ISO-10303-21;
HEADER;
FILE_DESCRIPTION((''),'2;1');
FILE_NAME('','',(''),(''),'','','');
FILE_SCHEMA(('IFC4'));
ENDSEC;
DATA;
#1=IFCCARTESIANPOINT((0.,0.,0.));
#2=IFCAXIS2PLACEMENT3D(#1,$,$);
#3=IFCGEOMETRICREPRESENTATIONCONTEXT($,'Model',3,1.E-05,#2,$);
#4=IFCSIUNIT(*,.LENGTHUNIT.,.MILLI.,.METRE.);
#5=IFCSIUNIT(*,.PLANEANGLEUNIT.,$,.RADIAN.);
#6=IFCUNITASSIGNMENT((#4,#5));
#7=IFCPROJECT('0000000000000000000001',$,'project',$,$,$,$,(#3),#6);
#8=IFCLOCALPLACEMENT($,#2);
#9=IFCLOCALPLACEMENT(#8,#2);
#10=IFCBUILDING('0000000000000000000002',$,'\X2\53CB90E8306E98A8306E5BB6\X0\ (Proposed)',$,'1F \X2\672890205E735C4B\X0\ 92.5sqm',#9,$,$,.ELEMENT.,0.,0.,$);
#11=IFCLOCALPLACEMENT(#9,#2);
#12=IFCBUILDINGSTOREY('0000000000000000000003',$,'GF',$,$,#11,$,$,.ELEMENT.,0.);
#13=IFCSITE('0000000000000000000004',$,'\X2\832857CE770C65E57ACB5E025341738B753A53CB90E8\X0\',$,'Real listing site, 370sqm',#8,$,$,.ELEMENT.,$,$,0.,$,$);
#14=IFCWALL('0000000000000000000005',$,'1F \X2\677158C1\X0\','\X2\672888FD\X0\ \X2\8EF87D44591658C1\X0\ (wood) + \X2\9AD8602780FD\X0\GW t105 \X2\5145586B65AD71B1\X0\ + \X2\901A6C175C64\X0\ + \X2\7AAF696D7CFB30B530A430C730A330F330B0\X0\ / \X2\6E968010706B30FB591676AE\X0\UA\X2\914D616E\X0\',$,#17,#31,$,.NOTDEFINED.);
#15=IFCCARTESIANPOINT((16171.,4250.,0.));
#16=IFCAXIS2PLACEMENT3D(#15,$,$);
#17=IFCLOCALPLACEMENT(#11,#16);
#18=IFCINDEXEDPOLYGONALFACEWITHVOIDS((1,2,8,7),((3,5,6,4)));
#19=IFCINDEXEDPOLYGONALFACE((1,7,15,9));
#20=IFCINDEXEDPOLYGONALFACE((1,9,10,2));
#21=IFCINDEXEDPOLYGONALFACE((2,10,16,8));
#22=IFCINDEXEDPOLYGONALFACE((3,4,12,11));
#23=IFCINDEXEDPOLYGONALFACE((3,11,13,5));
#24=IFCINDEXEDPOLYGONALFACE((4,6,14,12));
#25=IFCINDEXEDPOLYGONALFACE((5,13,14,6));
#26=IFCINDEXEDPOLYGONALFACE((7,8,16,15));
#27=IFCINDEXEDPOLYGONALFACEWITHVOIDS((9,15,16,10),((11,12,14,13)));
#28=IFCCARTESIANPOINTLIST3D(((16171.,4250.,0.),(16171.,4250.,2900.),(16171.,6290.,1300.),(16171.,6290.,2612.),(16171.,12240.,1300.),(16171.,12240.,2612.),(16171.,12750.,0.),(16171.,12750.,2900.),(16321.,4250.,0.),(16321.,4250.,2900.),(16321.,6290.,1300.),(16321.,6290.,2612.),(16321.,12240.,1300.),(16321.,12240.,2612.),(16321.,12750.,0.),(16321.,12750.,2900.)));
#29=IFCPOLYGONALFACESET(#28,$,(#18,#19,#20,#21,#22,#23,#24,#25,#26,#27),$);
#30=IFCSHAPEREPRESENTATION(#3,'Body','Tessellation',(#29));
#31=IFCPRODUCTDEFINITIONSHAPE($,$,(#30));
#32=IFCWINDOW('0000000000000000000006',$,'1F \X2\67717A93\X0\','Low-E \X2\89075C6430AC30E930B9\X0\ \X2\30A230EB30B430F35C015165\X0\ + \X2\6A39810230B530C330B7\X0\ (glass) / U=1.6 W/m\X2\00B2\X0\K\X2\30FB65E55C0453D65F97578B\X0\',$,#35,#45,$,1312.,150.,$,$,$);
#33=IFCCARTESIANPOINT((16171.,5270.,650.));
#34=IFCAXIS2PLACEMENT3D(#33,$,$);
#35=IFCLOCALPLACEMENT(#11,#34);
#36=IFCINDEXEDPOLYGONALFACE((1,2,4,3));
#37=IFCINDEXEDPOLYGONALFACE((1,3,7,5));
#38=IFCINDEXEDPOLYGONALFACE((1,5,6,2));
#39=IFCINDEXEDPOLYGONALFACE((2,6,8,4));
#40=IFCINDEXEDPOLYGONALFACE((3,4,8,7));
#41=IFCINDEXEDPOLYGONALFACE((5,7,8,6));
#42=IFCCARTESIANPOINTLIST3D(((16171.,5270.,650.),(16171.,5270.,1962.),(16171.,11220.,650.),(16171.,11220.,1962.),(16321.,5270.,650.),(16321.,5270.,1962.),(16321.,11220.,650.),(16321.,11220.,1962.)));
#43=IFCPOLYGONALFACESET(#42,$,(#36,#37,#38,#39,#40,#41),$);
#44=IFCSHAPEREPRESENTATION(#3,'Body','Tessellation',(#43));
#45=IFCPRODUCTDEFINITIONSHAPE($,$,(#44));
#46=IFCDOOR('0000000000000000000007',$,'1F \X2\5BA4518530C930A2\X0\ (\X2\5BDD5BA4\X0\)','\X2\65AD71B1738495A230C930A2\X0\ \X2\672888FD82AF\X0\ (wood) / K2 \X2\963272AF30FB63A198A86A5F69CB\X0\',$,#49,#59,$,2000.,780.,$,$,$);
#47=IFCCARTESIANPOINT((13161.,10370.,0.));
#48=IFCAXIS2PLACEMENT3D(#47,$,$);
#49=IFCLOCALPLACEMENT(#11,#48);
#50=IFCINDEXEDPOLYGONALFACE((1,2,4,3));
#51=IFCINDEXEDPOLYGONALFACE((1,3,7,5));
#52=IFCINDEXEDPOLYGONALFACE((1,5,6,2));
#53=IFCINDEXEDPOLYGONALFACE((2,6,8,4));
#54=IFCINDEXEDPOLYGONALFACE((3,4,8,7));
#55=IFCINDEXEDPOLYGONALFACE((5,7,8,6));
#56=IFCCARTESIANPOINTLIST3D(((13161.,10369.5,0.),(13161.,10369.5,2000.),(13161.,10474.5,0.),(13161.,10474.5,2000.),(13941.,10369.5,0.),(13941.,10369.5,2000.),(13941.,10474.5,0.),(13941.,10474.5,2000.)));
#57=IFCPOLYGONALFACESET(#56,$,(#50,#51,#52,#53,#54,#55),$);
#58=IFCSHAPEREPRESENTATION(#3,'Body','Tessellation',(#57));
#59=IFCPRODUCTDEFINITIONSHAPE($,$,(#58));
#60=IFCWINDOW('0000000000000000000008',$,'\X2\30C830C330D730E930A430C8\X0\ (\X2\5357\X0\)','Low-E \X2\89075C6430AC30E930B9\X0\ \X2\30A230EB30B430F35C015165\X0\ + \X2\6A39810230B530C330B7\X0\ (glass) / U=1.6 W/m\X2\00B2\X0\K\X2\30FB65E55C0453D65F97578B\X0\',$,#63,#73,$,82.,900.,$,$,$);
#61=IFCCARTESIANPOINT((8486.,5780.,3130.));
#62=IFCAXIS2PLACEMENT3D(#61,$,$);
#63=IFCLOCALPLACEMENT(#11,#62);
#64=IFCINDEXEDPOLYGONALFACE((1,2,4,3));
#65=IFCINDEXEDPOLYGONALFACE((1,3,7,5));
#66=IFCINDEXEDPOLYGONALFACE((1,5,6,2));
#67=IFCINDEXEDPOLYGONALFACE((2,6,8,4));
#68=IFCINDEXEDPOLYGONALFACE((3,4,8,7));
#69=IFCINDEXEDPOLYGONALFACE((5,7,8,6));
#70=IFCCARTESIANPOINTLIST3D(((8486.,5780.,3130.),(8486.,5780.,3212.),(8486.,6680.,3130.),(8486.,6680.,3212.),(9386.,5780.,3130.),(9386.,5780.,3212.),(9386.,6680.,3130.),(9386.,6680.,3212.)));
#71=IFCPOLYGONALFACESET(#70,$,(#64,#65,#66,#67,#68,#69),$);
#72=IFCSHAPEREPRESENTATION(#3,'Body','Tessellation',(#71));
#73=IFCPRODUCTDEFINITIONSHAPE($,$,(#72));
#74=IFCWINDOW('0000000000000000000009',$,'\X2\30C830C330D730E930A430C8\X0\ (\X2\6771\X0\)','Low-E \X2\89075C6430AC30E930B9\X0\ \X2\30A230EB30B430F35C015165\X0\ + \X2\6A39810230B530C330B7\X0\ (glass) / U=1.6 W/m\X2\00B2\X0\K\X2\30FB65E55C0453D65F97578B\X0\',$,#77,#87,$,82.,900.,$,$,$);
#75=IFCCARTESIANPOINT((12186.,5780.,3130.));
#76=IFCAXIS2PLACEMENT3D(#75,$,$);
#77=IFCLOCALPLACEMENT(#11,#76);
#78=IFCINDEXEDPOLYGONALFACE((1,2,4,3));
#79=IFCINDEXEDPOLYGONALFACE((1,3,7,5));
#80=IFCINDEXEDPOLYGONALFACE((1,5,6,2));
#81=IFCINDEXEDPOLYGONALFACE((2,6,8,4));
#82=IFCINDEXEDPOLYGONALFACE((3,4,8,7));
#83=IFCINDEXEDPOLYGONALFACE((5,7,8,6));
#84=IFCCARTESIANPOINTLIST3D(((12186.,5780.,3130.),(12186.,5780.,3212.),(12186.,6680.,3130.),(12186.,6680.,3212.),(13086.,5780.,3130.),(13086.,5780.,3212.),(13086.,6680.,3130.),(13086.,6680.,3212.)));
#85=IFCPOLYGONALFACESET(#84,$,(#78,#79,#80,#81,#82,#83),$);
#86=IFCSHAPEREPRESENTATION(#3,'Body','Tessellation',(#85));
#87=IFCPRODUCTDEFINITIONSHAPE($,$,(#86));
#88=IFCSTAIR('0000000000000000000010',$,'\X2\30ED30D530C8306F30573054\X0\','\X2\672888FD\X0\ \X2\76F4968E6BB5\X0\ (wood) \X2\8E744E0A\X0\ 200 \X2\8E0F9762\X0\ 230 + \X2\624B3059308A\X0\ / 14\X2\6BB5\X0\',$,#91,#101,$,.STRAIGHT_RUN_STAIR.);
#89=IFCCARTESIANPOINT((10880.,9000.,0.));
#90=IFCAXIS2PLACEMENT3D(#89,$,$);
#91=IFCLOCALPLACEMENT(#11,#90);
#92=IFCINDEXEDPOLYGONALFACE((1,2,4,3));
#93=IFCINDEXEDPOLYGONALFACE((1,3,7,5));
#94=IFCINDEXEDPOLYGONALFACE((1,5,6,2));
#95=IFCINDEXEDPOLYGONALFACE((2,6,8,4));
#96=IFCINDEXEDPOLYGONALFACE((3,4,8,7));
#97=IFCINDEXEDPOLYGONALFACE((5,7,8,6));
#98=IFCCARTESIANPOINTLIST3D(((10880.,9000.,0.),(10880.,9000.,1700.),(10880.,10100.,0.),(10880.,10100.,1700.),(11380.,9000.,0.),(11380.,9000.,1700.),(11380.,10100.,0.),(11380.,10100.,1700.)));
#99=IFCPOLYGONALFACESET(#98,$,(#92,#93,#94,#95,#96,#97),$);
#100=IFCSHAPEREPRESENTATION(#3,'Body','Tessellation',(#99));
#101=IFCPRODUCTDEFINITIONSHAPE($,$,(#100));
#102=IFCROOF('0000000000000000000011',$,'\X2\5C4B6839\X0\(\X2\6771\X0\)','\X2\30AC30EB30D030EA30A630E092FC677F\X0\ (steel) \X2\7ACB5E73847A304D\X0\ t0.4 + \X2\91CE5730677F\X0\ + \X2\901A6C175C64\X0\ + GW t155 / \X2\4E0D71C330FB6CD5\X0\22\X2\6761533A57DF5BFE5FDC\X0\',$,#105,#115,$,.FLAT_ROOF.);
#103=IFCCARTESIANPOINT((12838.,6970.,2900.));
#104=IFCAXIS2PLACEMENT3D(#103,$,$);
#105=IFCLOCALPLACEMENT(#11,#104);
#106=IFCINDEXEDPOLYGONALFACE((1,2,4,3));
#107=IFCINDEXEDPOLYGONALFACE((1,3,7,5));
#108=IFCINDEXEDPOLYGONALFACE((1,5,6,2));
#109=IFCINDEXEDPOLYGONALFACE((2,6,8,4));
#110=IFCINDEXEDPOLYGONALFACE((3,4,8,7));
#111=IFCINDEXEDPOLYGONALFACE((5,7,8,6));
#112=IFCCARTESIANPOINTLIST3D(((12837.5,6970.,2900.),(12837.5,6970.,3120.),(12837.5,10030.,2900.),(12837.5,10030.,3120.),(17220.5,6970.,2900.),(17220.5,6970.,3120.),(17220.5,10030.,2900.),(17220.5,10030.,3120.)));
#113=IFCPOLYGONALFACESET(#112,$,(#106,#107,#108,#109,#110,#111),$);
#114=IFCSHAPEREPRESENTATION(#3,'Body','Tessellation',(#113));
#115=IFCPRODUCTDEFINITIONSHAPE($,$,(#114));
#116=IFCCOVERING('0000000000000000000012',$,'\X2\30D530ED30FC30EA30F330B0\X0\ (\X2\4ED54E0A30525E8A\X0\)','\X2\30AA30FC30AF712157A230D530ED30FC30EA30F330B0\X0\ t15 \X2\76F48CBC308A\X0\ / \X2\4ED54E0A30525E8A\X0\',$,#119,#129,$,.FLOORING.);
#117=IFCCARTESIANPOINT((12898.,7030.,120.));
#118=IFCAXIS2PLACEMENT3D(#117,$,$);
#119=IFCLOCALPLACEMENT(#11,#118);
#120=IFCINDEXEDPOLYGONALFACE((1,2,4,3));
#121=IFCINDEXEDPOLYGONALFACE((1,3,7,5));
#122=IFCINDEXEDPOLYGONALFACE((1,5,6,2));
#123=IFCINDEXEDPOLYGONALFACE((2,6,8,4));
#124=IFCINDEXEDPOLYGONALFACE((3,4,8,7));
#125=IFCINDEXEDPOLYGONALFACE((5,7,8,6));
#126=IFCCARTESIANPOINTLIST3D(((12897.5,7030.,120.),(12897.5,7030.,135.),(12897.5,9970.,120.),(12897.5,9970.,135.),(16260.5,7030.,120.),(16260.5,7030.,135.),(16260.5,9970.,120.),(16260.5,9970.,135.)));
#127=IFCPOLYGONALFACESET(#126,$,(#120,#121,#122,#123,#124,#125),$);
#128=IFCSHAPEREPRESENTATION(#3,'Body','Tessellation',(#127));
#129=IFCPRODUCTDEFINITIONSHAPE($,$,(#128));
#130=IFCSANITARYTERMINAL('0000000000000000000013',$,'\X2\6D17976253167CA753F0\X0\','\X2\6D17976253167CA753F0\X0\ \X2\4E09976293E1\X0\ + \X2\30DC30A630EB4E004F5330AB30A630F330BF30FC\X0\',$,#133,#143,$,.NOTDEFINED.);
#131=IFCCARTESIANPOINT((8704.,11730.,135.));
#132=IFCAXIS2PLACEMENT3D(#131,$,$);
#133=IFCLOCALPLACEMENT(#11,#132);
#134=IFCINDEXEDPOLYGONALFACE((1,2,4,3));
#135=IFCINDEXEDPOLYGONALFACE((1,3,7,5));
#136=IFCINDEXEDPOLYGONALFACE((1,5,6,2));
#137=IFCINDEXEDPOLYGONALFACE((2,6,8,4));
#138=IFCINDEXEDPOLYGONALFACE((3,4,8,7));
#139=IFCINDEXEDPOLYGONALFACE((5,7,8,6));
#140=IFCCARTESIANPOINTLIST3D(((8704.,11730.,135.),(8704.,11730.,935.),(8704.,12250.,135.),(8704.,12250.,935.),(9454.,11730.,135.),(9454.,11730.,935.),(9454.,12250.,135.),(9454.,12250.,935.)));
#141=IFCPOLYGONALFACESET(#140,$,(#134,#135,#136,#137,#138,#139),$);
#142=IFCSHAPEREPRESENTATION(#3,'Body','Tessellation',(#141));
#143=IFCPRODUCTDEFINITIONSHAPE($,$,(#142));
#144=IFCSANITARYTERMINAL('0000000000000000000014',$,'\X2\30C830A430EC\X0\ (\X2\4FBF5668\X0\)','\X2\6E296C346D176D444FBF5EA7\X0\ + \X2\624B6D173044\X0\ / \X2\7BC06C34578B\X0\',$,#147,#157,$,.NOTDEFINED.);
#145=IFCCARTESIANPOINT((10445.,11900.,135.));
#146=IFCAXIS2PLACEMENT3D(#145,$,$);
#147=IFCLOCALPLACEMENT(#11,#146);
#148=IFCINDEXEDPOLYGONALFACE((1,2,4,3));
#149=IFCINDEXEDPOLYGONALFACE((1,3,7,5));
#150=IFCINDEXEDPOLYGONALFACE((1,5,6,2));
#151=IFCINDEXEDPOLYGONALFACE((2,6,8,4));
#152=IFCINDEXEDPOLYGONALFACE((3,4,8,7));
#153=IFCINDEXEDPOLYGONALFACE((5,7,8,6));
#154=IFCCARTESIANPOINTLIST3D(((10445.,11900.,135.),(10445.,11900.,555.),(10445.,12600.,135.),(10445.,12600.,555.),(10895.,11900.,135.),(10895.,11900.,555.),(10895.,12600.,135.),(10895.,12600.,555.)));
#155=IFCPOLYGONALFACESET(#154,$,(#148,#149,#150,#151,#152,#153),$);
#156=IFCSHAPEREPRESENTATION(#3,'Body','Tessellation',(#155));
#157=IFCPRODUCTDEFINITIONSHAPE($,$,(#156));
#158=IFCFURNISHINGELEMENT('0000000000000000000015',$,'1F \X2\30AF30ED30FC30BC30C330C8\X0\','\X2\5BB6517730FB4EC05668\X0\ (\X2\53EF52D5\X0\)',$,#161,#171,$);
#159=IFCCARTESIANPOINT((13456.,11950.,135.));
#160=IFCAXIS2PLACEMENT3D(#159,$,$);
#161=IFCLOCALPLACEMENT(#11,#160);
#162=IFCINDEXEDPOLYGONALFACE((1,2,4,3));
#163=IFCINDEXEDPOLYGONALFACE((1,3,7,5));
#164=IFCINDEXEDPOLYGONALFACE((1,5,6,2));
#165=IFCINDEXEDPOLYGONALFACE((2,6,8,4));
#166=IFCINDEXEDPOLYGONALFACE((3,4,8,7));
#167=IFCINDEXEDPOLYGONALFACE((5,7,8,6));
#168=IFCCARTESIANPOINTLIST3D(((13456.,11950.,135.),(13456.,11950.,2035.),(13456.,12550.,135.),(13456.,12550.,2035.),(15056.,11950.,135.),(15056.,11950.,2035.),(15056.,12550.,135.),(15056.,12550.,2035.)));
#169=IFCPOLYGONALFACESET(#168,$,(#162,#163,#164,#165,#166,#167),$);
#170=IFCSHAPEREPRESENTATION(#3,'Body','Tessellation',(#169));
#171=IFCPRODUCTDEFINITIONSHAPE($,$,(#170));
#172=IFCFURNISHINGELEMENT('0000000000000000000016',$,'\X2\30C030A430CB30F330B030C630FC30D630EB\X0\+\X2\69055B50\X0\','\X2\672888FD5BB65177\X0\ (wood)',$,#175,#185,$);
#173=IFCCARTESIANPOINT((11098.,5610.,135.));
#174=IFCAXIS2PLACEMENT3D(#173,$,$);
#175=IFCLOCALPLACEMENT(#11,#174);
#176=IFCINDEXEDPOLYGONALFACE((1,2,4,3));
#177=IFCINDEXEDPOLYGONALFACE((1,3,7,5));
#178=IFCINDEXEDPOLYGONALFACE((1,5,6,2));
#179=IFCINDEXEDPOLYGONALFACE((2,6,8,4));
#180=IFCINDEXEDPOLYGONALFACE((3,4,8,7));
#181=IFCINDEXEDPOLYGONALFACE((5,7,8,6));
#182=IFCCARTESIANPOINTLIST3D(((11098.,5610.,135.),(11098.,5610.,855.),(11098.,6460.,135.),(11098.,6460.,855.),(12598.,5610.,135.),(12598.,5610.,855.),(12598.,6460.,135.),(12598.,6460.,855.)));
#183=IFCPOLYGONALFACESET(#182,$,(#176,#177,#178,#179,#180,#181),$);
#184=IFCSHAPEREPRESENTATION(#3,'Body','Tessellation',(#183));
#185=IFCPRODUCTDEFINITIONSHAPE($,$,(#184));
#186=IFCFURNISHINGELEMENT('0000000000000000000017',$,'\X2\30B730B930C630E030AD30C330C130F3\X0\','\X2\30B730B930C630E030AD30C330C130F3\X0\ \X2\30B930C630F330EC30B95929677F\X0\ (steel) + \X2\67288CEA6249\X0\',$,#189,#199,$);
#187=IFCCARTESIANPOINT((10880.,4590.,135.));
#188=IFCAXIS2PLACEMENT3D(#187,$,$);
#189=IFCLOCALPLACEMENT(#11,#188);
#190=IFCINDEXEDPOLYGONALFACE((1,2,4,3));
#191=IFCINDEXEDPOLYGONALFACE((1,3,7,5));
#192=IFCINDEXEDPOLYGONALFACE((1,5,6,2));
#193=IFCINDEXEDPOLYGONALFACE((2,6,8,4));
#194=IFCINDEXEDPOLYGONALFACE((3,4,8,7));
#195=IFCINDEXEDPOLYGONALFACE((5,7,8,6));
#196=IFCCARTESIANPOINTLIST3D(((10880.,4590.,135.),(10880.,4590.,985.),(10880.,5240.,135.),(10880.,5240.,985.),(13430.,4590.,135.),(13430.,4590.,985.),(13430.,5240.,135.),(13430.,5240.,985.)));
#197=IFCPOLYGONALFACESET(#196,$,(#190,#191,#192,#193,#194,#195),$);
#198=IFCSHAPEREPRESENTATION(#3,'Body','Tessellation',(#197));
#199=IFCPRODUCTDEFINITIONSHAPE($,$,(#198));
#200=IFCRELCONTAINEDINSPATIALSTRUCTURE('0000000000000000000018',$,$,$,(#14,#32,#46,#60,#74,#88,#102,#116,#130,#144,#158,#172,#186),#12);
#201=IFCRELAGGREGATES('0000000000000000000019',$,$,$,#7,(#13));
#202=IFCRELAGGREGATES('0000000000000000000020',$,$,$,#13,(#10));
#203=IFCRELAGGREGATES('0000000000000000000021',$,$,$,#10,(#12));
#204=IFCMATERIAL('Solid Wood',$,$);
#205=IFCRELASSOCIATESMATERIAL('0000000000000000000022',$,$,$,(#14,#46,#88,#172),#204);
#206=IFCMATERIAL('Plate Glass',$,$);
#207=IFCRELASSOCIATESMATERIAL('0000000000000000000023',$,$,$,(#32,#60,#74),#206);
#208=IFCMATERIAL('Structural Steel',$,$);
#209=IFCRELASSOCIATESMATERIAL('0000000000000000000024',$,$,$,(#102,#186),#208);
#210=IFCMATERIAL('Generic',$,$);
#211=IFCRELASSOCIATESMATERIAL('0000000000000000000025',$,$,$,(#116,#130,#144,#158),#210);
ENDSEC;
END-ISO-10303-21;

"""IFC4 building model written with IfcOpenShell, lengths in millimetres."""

from ifc_helpers import new_model, si_unit, frame, frame_2d, origin, place, context, project, spatial, rectangle, extrude, material, element, fill, save


model = new_model("IFC4")

# Units and contexts
model_context = context("Model", 3, precision=1e-05, world=origin())
ifc_project = project(units=[si_unit("LENGTHUNIT", "METRE", prefix="MILLI"), si_unit("PLANEANGLEUNIT", "RADIAN")], contexts=[model_context])

# Site, building, storey
site_placement = place(None, origin())
site = spatial("IfcSite", under=ifc_project, at=site_placement, Name="茨城県日立市十王町友部", ObjectType="Real listing site, 370sqm", CompositionType="ELEMENT", RefElevation=0.0)
building_placement = place(site_placement, origin())
building = spatial("IfcBuilding", under=site, at=building_placement, Name="友部の風の家 (Proposed)", ObjectType="1F 木造平屋 92.5sqm", CompositionType="ELEMENT", ElevationOfRefHeight=0.0, ElevationOfTerrain=0.0)
storey_placement = place(building_placement, origin())
storey = spatial("IfcBuildingStorey", under=building, at=storey_placement, Name="GF", CompositionType="ELEMENT", Elevation=0.0)

# Shared definitions
ifc_material_1 = material(Name="Solid Wood")

# Wall, opening, window
wall_1_placement = place(storey_placement, frame((16171.0, 4250.0, 0.0)))
wall_1 = element("IfcWall", 1, at=wall_1_placement, inside=storey, material=ifc_material_1, Name="1F 東壁", Description="木製 軸組外壁 (wood) + 高性能GW t105 充填断熱 + 通気層 + 窯業系サイディング / 準耐火・外皮UA配慮", PredefinedType="NOTDEFINED", context=model_context, shape_type="SweptSolid", body=[
    extrude(rectangle(XDim=150.0, YDim=8500.0, at=frame_2d((75.0, 4250.0))), frame((16171.0, 4250.0, 0.0)), (0.0, 0.0, 1.0), 2900.0),
])
opening_1_placement = place(storey_placement, frame((16171.0, 5270.0, 650.0)))
opening_1 = element("IfcOpeningElement", 2, at=opening_1_placement, cuts=wall_1, PredefinedType="NOTDEFINED", context=model_context, shape_type="SweptSolid", body=[
    extrude(rectangle(XDim=150.0, YDim=5950.0, at=frame_2d((75.0, 2975.0))), frame((16171.0, 5270.0, 650.0)), (0.0, 0.0, 1.0), 1312.0),
])
ifc_material_2 = material(Name="Plate Glass")
window_1_placement = place(storey_placement, frame((16171.0, 5270.0, 650.0)))
window_1 = element("IfcWindow", 3, at=window_1_placement, inside=storey, material=ifc_material_2, Name="1F 東窓", Description="Low-E 複層ガラス アルゴン封入 + 樹脂サッシ (glass) / U=1.6 W/m²K・日射取得型", OverallHeight=1312.0, OverallWidth=150.0, context=model_context, shape_type="SweptSolid", body=[
    extrude(rectangle(XDim=150.0, YDim=5950.0, at=frame_2d((75.0, 2975.0))), frame((16171.0, 5270.0, 650.0)), (0.0, 0.0, 1.0), 1312.0),
])
fill(opening_1, window_1)

# Door
door_placement = place(storey_placement, frame((13161.0, 10370.0, 0.0)))
element("IfcDoor", 4, at=door_placement, inside=storey, material=ifc_material_1, Name="1F 室内ドア (寝室)", Description="断熱玄関ドア 木製芯 (wood) / K2 防犯・採風機構", OverallHeight=2000.0, OverallWidth=780.0, context=model_context, shape_type="SweptSolid", body=[
    extrude(rectangle(XDim=780.0, YDim=105.0, at=frame_2d((390.0, 52.0))), frame((13161.0, 10370.0, 0.0)), (0.0, 0.0, 1.0), 2000.0),
])

# Windows
window_2_placement = place(storey_placement, frame((8486.0, 5780.0, 3130.0)))
element("IfcWindow", 5, at=window_2_placement, inside=storey, material=ifc_material_2, Name="トップライト (南)", Description="Low-E 複層ガラス アルゴン封入 + 樹脂サッシ (glass) / U=1.6 W/m²K・日射取得型", OverallHeight=82.0, OverallWidth=900.0, context=model_context, shape_type="SweptSolid", body=[
    extrude(rectangle(XDim=900.0, YDim=900.0, at=frame_2d((450.0, 450.0))), frame((8486.0, 5780.0, 3130.0)), (0.0, 0.0, 1.0), 82.0),
])
window_3_placement = place(storey_placement, frame((12186.0, 5780.0, 3130.0)))
element("IfcWindow", 6, at=window_3_placement, inside=storey, material=ifc_material_2, Name="トップライト (東)", Description="Low-E 複層ガラス アルゴン封入 + 樹脂サッシ (glass) / U=1.6 W/m²K・日射取得型", OverallHeight=82.0, OverallWidth=900.0, context=model_context, shape_type="SweptSolid", body=[
    extrude(rectangle(XDim=900.0, YDim=900.0, at=frame_2d((450.0, 450.0))), frame((12186.0, 5780.0, 3130.0)), (0.0, 0.0, 1.0), 82.0),
])

# Stair
stair_placement = place(storey_placement, frame((10880.0, 9000.0, 0.0)))
element("IfcStair", 7, at=stair_placement, inside=storey, material=ifc_material_1, Name="ロフトはしご", Description="木製 直階段 (wood) 蹴上 200 踏面 230 + 手すり / 14段", PredefinedType="STRAIGHT_RUN_STAIR", context=model_context, shape_type="SweptSolid", body=[
    extrude(rectangle(XDim=500.0, YDim=1100.0, at=frame_2d((250.0, 550.0))), frame((10880.0, 9000.0, 0.0)), (0.0, 0.0, 1.0), 1700.0),
])

# Roof
ifc_material_3 = material(Name="Structural Steel")
roof_placement = place(storey_placement, frame((12838.0, 6970.0, 2900.0)))
element("IfcRoof", 8, at=roof_placement, inside=storey, material=ifc_material_3, Name="屋根(東)", Description="ガルバリウム鋼板 (steel) 立平葺き t0.4 + 野地板 + 通気層 + GW t155 / 不燃・法22条区域対応", PredefinedType="FLAT_ROOF", context=model_context, shape_type="SweptSolid", body=[
    extrude(rectangle(XDim=4383.0, YDim=3060.0, at=frame_2d((2191.0, 1530.0))), frame((12838.0, 6970.0, 2900.0)), (0.0, 0.0, 1.0), 220.0),
])

# Covering
ifc_material_4 = material(Name="Generic")
covering_placement = place(storey_placement, frame((12898.0, 7030.0, 120.0)))
element("IfcCovering", 9, at=covering_placement, inside=storey, material=ifc_material_4, Name="フローリング (仕上げ床)", Description="オーク無垢フローリング t15 直貼り / 仕上げ床", PredefinedType="FLOORING", context=model_context, shape_type="SweptSolid", body=[
    extrude(rectangle(XDim=3363.0, YDim=2940.0, at=frame_2d((1681.0, 1470.0))), frame((12898.0, 7030.0, 120.0)), (0.0, 0.0, 1.0), 15.0),
])

# Sanitary terminals
sanitary_terminal_1_placement = place(storey_placement, frame((8704.0, 11730.0, 135.0)))
element("IfcSanitaryTerminal", 10, at=sanitary_terminal_1_placement, inside=storey, material=ifc_material_4, Name="洗面化粧台", Description="洗面化粧台 三面鏡 + ボウル一体カウンター", PredefinedType="NOTDEFINED", context=model_context, shape_type="SweptSolid", body=[
    extrude(rectangle(XDim=750.0, YDim=520.0, at=frame_2d((375.0, 260.0))), frame((8704.0, 11730.0, 135.0)), (0.0, 0.0, 1.0), 800.0),
])
sanitary_terminal_2_placement = place(storey_placement, frame((10445.0, 11900.0, 135.0)))
element("IfcSanitaryTerminal", 11, at=sanitary_terminal_2_placement, inside=storey, material=ifc_material_4, Name="トイレ (便器)", Description="温水洗浄便座 + 手洗い / 節水型", PredefinedType="NOTDEFINED", context=model_context, shape_type="SweptSolid", body=[
    extrude(rectangle(XDim=450.0, YDim=700.0, at=frame_2d((225.0, 350.0))), frame((10445.0, 11900.0, 135.0)), (0.0, 0.0, 1.0), 420.0),
])

# Furnishing elements
furnishing_1_placement = place(storey_placement, frame((13456.0, 11950.0, 135.0)))
element("IfcFurnishingElement", 12, at=furnishing_1_placement, inside=storey, material=ifc_material_4, Name="1F クローゼット", Description="家具・什器 (可動)", context=model_context, shape_type="SweptSolid", body=[
    extrude(rectangle(XDim=1600.0, YDim=600.0, at=frame_2d((800.0, 300.0))), frame((13456.0, 11950.0, 135.0)), (0.0, 0.0, 1.0), 1900.0),
])
furnishing_2_placement = place(storey_placement, frame((11098.0, 5610.0, 135.0)))
element("IfcFurnishingElement", 13, at=furnishing_2_placement, inside=storey, material=ifc_material_1, Name="ダイニングテーブル+椅子", Description="木製家具 (wood)", context=model_context, shape_type="SweptSolid", body=[
    extrude(rectangle(XDim=1500.0, YDim=850.0, at=frame_2d((750.0, 425.0))), frame((11098.0, 5610.0, 135.0)), (0.0, 0.0, 1.0), 720.0),
])
furnishing_3_placement = place(storey_placement, frame((10880.0, 4590.0, 135.0)))
element("IfcFurnishingElement", 14, at=furnishing_3_placement, inside=storey, material=ifc_material_3, Name="システムキッチン", Description="システムキッチン ステンレス天板 (steel) + 木質扉", context=model_context, shape_type="SweptSolid", body=[
    extrude(rectangle(XDim=2550.0, YDim=650.0, at=frame_2d((1275.0, 325.0))), frame((10880.0, 4590.0, 135.0)), (0.0, 0.0, 1.0), 850.0),
])

save(model, "model.ifc")
